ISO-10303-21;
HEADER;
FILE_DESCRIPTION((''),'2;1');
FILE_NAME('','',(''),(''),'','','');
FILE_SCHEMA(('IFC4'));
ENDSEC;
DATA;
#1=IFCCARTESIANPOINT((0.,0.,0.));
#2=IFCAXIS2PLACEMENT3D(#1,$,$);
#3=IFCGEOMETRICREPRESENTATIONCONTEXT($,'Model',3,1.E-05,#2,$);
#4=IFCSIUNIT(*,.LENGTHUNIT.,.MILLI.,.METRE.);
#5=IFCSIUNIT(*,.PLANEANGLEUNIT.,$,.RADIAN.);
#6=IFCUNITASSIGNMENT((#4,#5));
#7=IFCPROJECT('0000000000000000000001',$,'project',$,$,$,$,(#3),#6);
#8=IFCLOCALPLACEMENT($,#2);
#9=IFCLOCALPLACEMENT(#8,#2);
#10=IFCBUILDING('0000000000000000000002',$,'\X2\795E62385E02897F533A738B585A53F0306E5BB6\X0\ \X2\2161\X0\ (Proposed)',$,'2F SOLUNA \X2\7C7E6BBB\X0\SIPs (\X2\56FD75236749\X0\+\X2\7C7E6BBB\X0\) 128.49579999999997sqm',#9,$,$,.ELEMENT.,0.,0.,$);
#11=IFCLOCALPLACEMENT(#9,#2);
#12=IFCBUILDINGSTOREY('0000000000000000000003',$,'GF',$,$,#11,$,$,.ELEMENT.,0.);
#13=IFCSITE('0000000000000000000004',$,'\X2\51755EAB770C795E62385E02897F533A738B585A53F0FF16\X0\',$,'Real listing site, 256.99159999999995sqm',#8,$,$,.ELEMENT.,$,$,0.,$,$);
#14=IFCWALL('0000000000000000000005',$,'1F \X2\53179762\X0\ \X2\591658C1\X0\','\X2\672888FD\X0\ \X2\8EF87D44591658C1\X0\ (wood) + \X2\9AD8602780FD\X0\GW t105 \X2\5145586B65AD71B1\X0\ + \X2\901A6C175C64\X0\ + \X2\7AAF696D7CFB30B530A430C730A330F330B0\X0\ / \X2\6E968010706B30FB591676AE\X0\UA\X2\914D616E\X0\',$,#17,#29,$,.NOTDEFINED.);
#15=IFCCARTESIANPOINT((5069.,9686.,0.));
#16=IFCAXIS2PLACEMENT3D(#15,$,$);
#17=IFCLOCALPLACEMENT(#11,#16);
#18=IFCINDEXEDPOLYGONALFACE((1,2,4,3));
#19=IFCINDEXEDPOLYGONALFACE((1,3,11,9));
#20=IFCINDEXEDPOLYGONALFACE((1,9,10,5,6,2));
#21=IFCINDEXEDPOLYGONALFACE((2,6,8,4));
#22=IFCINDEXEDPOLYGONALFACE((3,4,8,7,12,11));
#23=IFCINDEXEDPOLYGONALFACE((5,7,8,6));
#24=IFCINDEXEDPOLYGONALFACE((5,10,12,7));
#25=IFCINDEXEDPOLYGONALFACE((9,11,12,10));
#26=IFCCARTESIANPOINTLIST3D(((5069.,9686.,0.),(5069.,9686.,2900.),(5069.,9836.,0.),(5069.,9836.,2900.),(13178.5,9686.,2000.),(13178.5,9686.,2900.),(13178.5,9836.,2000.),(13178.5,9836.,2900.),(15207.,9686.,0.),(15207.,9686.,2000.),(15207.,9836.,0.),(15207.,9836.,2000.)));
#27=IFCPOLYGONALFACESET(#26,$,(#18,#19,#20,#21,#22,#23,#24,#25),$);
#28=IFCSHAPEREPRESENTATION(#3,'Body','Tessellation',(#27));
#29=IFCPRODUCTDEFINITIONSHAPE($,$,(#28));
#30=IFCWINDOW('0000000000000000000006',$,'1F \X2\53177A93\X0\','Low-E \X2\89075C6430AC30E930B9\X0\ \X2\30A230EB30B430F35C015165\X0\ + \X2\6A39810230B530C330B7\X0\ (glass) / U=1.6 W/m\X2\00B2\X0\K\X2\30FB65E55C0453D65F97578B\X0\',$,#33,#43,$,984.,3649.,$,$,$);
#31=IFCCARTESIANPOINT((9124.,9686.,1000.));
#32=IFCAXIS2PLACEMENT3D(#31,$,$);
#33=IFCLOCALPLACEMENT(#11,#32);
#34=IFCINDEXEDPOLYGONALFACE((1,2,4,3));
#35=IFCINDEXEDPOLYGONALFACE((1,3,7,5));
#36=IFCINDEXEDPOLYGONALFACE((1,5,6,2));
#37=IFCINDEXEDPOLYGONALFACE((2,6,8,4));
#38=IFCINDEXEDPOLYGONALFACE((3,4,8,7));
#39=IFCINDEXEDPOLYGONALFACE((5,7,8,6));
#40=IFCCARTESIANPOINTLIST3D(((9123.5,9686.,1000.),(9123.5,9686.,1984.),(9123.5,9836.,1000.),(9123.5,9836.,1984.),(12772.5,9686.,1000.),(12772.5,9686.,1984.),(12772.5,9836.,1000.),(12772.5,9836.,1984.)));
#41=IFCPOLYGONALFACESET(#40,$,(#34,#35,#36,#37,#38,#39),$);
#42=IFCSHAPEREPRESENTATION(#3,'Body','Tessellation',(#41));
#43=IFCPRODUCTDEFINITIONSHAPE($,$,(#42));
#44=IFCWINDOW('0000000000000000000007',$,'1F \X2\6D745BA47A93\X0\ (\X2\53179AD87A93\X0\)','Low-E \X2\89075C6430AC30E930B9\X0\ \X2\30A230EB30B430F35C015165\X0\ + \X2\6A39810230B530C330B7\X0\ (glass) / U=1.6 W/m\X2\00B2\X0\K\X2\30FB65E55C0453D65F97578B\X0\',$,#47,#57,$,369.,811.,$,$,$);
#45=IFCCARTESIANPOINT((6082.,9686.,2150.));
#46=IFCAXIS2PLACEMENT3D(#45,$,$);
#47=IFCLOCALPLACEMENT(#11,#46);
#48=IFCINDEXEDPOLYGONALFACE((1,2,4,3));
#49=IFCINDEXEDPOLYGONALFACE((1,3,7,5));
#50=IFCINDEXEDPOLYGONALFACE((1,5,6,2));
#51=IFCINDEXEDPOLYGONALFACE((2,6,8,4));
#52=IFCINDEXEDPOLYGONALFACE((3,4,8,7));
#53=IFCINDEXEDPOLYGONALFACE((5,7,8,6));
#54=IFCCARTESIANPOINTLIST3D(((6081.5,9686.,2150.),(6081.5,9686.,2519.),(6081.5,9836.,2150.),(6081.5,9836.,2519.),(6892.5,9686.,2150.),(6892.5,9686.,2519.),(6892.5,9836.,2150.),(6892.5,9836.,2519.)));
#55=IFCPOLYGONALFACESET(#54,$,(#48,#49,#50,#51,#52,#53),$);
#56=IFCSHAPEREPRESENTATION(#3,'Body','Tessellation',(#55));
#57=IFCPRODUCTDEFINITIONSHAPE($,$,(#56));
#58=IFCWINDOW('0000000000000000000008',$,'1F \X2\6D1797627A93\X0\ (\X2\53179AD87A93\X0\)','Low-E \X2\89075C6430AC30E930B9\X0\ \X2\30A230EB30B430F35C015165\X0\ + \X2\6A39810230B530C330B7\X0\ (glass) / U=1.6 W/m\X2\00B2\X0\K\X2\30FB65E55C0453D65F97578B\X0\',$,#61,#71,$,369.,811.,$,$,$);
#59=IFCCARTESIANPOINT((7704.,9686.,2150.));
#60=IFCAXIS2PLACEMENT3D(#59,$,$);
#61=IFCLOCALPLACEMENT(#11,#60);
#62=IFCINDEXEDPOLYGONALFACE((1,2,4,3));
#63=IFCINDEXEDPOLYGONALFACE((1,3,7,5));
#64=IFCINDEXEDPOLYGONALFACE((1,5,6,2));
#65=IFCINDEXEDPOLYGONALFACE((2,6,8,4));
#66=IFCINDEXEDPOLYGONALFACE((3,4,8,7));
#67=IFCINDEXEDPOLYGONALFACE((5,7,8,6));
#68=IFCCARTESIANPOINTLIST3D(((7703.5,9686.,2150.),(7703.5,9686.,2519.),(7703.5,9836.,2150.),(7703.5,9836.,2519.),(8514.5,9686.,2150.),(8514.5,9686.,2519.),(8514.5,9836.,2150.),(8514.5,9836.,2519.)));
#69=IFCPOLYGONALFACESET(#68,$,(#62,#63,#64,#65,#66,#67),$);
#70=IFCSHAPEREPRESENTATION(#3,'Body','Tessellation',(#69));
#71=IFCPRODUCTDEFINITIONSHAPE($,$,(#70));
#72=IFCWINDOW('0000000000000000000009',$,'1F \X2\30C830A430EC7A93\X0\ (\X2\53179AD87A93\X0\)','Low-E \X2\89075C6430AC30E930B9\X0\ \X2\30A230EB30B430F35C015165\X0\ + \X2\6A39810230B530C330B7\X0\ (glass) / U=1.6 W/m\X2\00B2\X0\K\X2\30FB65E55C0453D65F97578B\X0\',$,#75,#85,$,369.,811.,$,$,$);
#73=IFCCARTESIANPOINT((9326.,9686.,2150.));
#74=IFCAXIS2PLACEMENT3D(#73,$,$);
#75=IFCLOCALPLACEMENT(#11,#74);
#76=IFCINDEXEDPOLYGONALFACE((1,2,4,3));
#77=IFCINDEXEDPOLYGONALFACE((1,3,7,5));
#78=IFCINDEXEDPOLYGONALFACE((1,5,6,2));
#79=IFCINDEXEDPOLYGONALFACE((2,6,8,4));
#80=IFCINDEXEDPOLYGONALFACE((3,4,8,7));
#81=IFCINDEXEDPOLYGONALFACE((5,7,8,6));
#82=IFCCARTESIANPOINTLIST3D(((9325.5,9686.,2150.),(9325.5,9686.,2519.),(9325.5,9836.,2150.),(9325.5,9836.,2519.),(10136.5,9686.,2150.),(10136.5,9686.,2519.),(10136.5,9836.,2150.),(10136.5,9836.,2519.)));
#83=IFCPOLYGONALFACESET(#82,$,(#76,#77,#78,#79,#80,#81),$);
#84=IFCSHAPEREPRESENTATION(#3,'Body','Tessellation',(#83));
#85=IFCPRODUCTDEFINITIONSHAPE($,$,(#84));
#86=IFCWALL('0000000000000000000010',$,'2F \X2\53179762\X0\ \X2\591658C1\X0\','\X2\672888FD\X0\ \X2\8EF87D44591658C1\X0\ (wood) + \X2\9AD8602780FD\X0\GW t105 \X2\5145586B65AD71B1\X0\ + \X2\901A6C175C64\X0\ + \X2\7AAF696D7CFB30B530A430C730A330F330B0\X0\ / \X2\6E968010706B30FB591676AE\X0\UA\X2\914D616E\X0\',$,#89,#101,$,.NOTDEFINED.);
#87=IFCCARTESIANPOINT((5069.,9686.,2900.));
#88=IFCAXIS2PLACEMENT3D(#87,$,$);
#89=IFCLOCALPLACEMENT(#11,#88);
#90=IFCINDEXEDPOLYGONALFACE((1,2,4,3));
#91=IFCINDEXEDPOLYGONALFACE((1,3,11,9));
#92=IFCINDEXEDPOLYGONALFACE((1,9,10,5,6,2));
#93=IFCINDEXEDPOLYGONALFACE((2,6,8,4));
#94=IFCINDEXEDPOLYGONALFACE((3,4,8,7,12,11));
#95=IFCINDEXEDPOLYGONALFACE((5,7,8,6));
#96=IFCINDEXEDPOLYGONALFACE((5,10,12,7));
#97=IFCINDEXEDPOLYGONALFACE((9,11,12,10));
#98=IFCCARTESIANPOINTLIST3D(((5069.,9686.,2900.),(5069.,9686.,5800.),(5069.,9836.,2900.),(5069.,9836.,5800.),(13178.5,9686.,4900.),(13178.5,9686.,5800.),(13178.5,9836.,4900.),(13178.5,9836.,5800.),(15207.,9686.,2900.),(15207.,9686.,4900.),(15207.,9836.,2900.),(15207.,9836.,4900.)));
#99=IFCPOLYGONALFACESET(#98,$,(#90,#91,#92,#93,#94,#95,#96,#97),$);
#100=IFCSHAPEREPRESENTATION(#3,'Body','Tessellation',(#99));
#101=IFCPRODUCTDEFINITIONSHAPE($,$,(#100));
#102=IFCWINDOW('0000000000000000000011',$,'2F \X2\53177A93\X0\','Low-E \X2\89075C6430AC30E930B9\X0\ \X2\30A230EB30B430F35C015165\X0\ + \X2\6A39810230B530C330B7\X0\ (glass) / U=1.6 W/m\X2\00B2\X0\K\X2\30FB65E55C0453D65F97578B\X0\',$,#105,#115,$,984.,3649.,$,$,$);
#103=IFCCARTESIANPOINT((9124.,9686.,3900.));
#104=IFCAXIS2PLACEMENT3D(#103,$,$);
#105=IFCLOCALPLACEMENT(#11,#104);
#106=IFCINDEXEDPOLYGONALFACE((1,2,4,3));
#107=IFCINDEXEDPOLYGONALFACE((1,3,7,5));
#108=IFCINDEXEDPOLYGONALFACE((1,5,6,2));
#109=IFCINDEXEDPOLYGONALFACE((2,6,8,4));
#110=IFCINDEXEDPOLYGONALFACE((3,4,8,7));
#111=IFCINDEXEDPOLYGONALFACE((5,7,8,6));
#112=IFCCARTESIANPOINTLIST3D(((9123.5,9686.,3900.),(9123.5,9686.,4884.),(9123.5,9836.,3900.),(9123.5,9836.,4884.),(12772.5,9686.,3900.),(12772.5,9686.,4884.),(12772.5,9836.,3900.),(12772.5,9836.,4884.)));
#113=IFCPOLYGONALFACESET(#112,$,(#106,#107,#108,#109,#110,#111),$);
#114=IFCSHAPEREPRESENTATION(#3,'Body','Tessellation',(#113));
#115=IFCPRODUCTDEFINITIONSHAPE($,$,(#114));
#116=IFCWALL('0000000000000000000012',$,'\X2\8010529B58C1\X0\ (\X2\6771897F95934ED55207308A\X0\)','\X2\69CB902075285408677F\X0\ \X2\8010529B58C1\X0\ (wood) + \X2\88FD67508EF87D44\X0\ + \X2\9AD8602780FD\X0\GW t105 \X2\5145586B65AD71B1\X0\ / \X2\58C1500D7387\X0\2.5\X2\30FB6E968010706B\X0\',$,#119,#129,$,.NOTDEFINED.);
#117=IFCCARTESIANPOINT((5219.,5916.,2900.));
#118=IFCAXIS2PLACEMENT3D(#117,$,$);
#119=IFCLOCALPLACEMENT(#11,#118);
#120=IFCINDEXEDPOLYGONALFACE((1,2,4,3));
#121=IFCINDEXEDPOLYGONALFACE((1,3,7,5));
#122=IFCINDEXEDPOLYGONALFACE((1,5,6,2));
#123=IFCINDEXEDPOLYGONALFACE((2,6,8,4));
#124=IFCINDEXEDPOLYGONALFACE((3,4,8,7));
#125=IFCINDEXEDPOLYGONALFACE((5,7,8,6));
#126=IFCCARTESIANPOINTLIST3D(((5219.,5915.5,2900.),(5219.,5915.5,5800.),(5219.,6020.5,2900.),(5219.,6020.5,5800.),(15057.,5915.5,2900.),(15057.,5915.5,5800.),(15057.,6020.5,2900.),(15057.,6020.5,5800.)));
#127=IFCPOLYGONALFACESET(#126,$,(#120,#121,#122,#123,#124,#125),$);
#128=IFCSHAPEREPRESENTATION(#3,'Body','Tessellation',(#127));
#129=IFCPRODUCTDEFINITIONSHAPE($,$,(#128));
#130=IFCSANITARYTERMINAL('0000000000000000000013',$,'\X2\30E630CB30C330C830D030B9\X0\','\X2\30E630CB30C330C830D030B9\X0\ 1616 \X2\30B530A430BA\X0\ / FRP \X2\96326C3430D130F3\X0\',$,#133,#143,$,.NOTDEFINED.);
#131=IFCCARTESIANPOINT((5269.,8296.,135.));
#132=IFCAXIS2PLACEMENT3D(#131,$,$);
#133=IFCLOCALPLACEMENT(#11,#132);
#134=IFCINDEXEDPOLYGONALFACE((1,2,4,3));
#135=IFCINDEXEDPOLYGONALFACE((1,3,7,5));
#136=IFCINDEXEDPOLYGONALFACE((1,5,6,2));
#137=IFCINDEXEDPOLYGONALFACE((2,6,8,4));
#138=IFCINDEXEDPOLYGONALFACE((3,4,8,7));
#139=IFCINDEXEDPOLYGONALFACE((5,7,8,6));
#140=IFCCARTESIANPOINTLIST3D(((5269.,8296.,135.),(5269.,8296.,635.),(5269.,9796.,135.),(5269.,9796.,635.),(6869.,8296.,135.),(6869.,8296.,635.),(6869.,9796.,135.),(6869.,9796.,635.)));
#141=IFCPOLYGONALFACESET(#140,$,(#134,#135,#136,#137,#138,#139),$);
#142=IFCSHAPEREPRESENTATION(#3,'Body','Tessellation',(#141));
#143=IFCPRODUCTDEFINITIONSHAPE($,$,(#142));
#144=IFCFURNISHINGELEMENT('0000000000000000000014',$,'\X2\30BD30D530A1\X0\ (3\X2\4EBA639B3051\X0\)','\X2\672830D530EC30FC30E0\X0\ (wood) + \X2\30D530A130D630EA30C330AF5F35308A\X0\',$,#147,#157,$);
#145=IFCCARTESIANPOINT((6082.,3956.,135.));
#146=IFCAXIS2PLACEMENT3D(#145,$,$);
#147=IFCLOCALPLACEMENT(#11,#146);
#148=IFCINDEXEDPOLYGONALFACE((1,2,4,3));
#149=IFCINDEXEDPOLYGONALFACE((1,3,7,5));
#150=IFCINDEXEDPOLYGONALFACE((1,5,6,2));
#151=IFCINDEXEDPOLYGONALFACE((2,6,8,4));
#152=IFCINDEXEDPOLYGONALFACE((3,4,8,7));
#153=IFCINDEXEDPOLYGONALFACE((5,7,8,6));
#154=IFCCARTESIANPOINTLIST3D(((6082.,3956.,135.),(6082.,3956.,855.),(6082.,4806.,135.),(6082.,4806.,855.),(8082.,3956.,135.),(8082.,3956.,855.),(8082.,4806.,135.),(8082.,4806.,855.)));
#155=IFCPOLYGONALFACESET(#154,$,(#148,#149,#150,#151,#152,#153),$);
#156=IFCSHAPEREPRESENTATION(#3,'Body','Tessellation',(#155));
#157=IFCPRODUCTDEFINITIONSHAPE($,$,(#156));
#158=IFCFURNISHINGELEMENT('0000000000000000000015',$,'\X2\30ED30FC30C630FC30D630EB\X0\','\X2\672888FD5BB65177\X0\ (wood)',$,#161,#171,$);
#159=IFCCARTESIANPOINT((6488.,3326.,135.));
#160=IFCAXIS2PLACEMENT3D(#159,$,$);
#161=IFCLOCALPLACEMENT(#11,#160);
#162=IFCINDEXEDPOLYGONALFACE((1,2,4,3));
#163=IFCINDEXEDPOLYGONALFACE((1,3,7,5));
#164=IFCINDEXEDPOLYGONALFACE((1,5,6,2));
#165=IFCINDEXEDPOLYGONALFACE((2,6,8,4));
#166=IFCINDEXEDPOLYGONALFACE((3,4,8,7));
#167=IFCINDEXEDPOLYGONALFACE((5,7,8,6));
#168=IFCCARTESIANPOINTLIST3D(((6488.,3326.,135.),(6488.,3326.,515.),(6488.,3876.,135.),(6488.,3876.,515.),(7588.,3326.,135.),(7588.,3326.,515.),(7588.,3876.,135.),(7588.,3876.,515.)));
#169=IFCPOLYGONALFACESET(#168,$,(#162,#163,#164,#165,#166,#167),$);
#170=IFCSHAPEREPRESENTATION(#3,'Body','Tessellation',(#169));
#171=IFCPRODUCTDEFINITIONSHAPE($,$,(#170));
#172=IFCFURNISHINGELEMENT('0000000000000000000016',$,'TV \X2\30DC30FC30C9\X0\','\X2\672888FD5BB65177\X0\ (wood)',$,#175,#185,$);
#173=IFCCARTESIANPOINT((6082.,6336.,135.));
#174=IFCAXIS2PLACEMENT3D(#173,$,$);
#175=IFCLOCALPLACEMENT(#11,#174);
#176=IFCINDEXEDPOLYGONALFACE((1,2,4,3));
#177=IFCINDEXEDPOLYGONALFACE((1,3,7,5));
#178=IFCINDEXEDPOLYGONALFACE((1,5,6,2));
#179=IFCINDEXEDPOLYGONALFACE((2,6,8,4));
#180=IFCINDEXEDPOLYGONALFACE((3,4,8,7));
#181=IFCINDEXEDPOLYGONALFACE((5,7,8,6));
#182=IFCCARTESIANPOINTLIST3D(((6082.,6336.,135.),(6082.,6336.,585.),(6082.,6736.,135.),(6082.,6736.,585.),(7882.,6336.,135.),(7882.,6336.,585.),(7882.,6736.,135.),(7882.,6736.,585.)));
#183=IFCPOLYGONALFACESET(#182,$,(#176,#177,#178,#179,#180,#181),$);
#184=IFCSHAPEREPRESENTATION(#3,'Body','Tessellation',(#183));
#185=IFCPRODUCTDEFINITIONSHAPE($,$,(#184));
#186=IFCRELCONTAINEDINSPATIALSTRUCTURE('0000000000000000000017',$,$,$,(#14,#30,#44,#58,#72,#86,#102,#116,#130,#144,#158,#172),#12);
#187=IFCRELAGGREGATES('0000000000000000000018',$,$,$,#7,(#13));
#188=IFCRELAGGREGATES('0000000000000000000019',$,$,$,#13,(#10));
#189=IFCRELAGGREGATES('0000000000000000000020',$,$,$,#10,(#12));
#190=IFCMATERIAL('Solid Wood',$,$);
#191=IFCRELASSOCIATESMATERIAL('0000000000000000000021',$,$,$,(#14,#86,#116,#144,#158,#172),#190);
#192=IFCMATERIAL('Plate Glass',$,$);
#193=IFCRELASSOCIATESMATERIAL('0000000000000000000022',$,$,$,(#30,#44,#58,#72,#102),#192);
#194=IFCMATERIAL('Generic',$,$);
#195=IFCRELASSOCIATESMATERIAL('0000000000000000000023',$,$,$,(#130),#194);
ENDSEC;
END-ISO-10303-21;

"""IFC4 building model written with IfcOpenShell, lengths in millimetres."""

from ifc_helpers import new_model, si_unit, frame, frame_2d, origin, place, context, project, spatial, rectangle, extrude, material, element, fill, save


model = new_model("IFC4")

# Units and contexts
model_context = context("Model", 3, precision=1e-05, world=origin())
ifc_project = project(units=[si_unit("LENGTHUNIT", "METRE", prefix="MILLI"), si_unit("PLANEANGLEUNIT", "RADIAN")], contexts=[model_context])

# Site, building, storey
site_placement = place(None, origin())
site = spatial("IfcSite", under=ifc_project, at=site_placement, Name="兵庫県神戸市西区王塚台６", ObjectType="Real listing site, 256.99159999999995sqm", CompositionType="ELEMENT", RefElevation=0.0)
building_placement = place(site_placement, origin())
building = spatial("IfcBuilding", under=site, at=building_placement, Name="神戸市西区王塚台の家 Ⅱ (Proposed)", ObjectType="2F SOLUNA 籾殻SIPs (国産杉+籾殻) 128.49579999999997sqm", CompositionType="ELEMENT", ElevationOfRefHeight=0.0, ElevationOfTerrain=0.0)
storey_placement = place(building_placement, origin())
storey = spatial("IfcBuildingStorey", under=building, at=storey_placement, Name="GF", CompositionType="ELEMENT", Elevation=0.0)

# Wall, openings, windows
ifc_material_1 = material(Name="Solid Wood")
wall_1_placement = place(storey_placement, frame((5069.0, 9686.0, 0.0)))
wall_1 = element("IfcWall", 1, at=wall_1_placement, inside=storey, material=ifc_material_1, Name="1F 北面 外壁", Description="木製 軸組外壁 (wood) + 高性能GW t105 充填断熱 + 通気層 + 窯業系サイディング / 準耐火・外皮UA配慮", PredefinedType="NOTDEFINED", context=model_context, shape_type="SweptSolid", body=[
    extrude(rectangle(XDim=10138.0, YDim=150.0, at=frame_2d((5069.0, 75.0))), frame((5069.0, 9686.0, 0.0)), (0.0, 0.0, 1.0), 2900.0),
])
opening_1_placement = place(storey_placement, frame((9124.0, 9686.0, 1000.0)))
opening_1 = element("IfcOpeningElement", 2, at=opening_1_placement, cuts=wall_1, PredefinedType="NOTDEFINED", context=model_context, shape_type="SweptSolid", body=[
    extrude(rectangle(XDim=3649.0, YDim=150.0, at=frame_2d((1824.0, 75.0))), frame((9124.0, 9686.0, 1000.0)), (0.0, 0.0, 1.0), 984.0),
])
opening_2_placement = place(storey_placement, frame((6082.0, 9686.0, 2150.0)))
opening_2 = element("IfcOpeningElement", 3, at=opening_2_placement, cuts=wall_1, PredefinedType="NOTDEFINED", context=model_context, shape_type="SweptSolid", body=[
    extrude(rectangle(XDim=811.0, YDim=150.0, at=frame_2d((405.0, 75.0))), frame((6082.0, 9686.0, 2150.0)), (0.0, 0.0, 1.0), 369.0),
])
opening_3_placement = place(storey_placement, frame((7704.0, 9686.0, 2150.0)))
opening_3 = element("IfcOpeningElement", 4, at=opening_3_placement, cuts=wall_1, PredefinedType="NOTDEFINED", context=model_context, shape_type="SweptSolid", body=[
    extrude(rectangle(XDim=811.0, YDim=150.0, at=frame_2d((405.0, 75.0))), frame((7704.0, 9686.0, 2150.0)), (0.0, 0.0, 1.0), 369.0),
])
opening_4_placement = place(storey_placement, frame((9326.0, 9686.0, 2150.0)))
opening_4 = element("IfcOpeningElement", 5, at=opening_4_placement, cuts=wall_1, PredefinedType="NOTDEFINED", context=model_context, shape_type="SweptSolid", body=[
    extrude(rectangle(XDim=811.0, YDim=150.0, at=frame_2d((405.0, 75.0))), frame((9326.0, 9686.0, 2150.0)), (0.0, 0.0, 1.0), 369.0),
])
ifc_material_2 = material(Name="Plate Glass")
window_1_placement = place(storey_placement, frame((9124.0, 9686.0, 1000.0)))
window_1 = element("IfcWindow", 6, at=window_1_placement, inside=storey, material=ifc_material_2, Name="1F 北窓", Description="Low-E 複層ガラス アルゴン封入 + 樹脂サッシ (glass) / U=1.6 W/m²K・日射取得型", OverallHeight=984.0, OverallWidth=3649.0, context=model_context, shape_type="SweptSolid", body=[
    extrude(rectangle(XDim=3649.0, YDim=150.0, at=frame_2d((1824.0, 75.0))), frame((9124.0, 9686.0, 1000.0)), (0.0, 0.0, 1.0), 984.0),
])
fill(opening_1, window_1)
window_2_placement = place(storey_placement, frame((6082.0, 9686.0, 2150.0)))
window_2 = element("IfcWindow", 7, at=window_2_placement, inside=storey, material=ifc_material_2, Name="1F 浴室窓 (北高窓)", Description="Low-E 複層ガラス アルゴン封入 + 樹脂サッシ (glass) / U=1.6 W/m²K・日射取得型", OverallHeight=369.0, OverallWidth=811.0, context=model_context, shape_type="SweptSolid", body=[
    extrude(rectangle(XDim=811.0, YDim=150.0, at=frame_2d((405.0, 75.0))), frame((6082.0, 9686.0, 2150.0)), (0.0, 0.0, 1.0), 369.0),
])
fill(opening_2, window_2)
window_3_placement = place(storey_placement, frame((7704.0, 9686.0, 2150.0)))
window_3 = element("IfcWindow", 8, at=window_3_placement, inside=storey, material=ifc_material_2, Name="1F 洗面窓 (北高窓)", Description="Low-E 複層ガラス アルゴン封入 + 樹脂サッシ (glass) / U=1.6 W/m²K・日射取得型", OverallHeight=369.0, OverallWidth=811.0, context=model_context, shape_type="SweptSolid", body=[
    extrude(rectangle(XDim=811.0, YDim=150.0, at=frame_2d((405.0, 75.0))), frame((7704.0, 9686.0, 2150.0)), (0.0, 0.0, 1.0), 369.0),
])
fill(opening_3, window_3)
window_4_placement = place(storey_placement, frame((9326.0, 9686.0, 2150.0)))
window_4 = element("IfcWindow", 9, at=window_4_placement, inside=storey, material=ifc_material_2, Name="1F トイレ窓 (北高窓)", Description="Low-E 複層ガラス アルゴン封入 + 樹脂サッシ (glass) / U=1.6 W/m²K・日射取得型", OverallHeight=369.0, OverallWidth=811.0, context=model_context, shape_type="SweptSolid", body=[
    extrude(rectangle(XDim=811.0, YDim=150.0, at=frame_2d((405.0, 75.0))), frame((9326.0, 9686.0, 2150.0)), (0.0, 0.0, 1.0), 369.0),
])
fill(opening_4, window_4)

# Wall, opening, window
wall_2_placement = place(storey_placement, frame((5069.0, 9686.0, 2900.0)))
wall_2 = element("IfcWall", 10, at=wall_2_placement, inside=storey, material=ifc_material_1, Name="2F 北面 外壁", Description="木製 軸組外壁 (wood) + 高性能GW t105 充填断熱 + 通気層 + 窯業系サイディング / 準耐火・外皮UA配慮", PredefinedType="NOTDEFINED", context=model_context, shape_type="SweptSolid", body=[
    extrude(rectangle(XDim=10138.0, YDim=150.0, at=frame_2d((5069.0, 75.0))), frame((5069.0, 9686.0, 2900.0)), (0.0, 0.0, 1.0), 2900.0),
])
opening_5_placement = place(storey_placement, frame((9124.0, 9686.0, 3900.0)))
opening_5 = element("IfcOpeningElement", 11, at=opening_5_placement, cuts=wall_2, PredefinedType="NOTDEFINED", context=model_context, shape_type="SweptSolid", body=[
    extrude(rectangle(XDim=3649.0, YDim=150.0, at=frame_2d((1824.0, 75.0))), frame((9124.0, 9686.0, 3900.0)), (0.0, 0.0, 1.0), 984.0),
])
window_5_placement = place(storey_placement, frame((9124.0, 9686.0, 3900.0)))
window_5 = element("IfcWindow", 12, at=window_5_placement, inside=storey, material=ifc_material_2, Name="2F 北窓", Description="Low-E 複層ガラス アルゴン封入 + 樹脂サッシ (glass) / U=1.6 W/m²K・日射取得型", OverallHeight=984.0, OverallWidth=3649.0, context=model_context, shape_type="SweptSolid", body=[
    extrude(rectangle(XDim=3649.0, YDim=150.0, at=frame_2d((1824.0, 75.0))), frame((9124.0, 9686.0, 3900.0)), (0.0, 0.0, 1.0), 984.0),
])
fill(opening_5, window_5)

# Wall
wall_3_placement = place(storey_placement, frame((5219.0, 5916.0, 2900.0)))
element("IfcWall", 13, at=wall_3_placement, inside=storey, material=ifc_material_1, Name="耐力壁 (東西間仕切り)", Description="構造用合板 耐力壁 (wood) + 製材軸組 + 高性能GW t105 充填断熱 / 壁倍率2.5・準耐火", PredefinedType="NOTDEFINED", context=model_context, shape_type="SweptSolid", body=[
    extrude(rectangle(XDim=9838.0, YDim=105.0, at=frame_2d((4919.0, 52.0))), frame((5219.0, 5916.0, 2900.0)), (0.0, 0.0, 1.0), 2900.0),
])

# Sanitary terminal
ifc_material_3 = material(Name="Generic")
sanitary_terminal_placement = place(storey_placement, frame((5269.0, 8296.0, 135.0)))
element("IfcSanitaryTerminal", 14, at=sanitary_terminal_placement, inside=storey, material=ifc_material_3, Name="ユニットバス", Description="ユニットバス 1616 サイズ / FRP 防水パン", PredefinedType="NOTDEFINED", context=model_context, shape_type="SweptSolid", body=[
    extrude(rectangle(XDim=1600.0, YDim=1500.0, at=frame_2d((800.0, 750.0))), frame((5269.0, 8296.0, 135.0)), (0.0, 0.0, 1.0), 500.0),
])

# Furnishing elements
furnishing_1_placement = place(storey_placement, frame((6082.0, 3956.0, 135.0)))
element("IfcFurnishingElement", 15, at=furnishing_1_placement, inside=storey, material=ifc_material_1, Name="ソファ (3人掛け)", Description="木フレーム (wood) + ファブリック張り", context=model_context, shape_type="SweptSolid", body=[
    extrude(rectangle(XDim=2000.0, YDim=850.0, at=frame_2d((1000.0, 425.0))), frame((6082.0, 3956.0, 135.0)), (0.0, 0.0, 1.0), 720.0),
])
furnishing_2_placement = place(storey_placement, frame((6488.0, 3326.0, 135.0)))
element("IfcFurnishingElement", 16, at=furnishing_2_placement, inside=storey, material=ifc_material_1, Name="ローテーブル", Description="木製家具 (wood)", context=model_context, shape_type="SweptSolid", body=[
    extrude(rectangle(XDim=1100.0, YDim=550.0, at=frame_2d((550.0, 275.0))), frame((6488.0, 3326.0, 135.0)), (0.0, 0.0, 1.0), 380.0),
])
furnishing_3_placement = place(storey_placement, frame((6082.0, 6336.0, 135.0)))
element("IfcFurnishingElement", 17, at=furnishing_3_placement, inside=storey, material=ifc_material_1, Name="TV ボード", Description="木製家具 (wood)", context=model_context, shape_type="SweptSolid", body=[
    extrude(rectangle(XDim=1800.0, YDim=400.0, at=frame_2d((900.0, 200.0))), frame((6082.0, 6336.0, 135.0)), (0.0, 0.0, 1.0), 450.0),
])

save(model, "model.ifc")
